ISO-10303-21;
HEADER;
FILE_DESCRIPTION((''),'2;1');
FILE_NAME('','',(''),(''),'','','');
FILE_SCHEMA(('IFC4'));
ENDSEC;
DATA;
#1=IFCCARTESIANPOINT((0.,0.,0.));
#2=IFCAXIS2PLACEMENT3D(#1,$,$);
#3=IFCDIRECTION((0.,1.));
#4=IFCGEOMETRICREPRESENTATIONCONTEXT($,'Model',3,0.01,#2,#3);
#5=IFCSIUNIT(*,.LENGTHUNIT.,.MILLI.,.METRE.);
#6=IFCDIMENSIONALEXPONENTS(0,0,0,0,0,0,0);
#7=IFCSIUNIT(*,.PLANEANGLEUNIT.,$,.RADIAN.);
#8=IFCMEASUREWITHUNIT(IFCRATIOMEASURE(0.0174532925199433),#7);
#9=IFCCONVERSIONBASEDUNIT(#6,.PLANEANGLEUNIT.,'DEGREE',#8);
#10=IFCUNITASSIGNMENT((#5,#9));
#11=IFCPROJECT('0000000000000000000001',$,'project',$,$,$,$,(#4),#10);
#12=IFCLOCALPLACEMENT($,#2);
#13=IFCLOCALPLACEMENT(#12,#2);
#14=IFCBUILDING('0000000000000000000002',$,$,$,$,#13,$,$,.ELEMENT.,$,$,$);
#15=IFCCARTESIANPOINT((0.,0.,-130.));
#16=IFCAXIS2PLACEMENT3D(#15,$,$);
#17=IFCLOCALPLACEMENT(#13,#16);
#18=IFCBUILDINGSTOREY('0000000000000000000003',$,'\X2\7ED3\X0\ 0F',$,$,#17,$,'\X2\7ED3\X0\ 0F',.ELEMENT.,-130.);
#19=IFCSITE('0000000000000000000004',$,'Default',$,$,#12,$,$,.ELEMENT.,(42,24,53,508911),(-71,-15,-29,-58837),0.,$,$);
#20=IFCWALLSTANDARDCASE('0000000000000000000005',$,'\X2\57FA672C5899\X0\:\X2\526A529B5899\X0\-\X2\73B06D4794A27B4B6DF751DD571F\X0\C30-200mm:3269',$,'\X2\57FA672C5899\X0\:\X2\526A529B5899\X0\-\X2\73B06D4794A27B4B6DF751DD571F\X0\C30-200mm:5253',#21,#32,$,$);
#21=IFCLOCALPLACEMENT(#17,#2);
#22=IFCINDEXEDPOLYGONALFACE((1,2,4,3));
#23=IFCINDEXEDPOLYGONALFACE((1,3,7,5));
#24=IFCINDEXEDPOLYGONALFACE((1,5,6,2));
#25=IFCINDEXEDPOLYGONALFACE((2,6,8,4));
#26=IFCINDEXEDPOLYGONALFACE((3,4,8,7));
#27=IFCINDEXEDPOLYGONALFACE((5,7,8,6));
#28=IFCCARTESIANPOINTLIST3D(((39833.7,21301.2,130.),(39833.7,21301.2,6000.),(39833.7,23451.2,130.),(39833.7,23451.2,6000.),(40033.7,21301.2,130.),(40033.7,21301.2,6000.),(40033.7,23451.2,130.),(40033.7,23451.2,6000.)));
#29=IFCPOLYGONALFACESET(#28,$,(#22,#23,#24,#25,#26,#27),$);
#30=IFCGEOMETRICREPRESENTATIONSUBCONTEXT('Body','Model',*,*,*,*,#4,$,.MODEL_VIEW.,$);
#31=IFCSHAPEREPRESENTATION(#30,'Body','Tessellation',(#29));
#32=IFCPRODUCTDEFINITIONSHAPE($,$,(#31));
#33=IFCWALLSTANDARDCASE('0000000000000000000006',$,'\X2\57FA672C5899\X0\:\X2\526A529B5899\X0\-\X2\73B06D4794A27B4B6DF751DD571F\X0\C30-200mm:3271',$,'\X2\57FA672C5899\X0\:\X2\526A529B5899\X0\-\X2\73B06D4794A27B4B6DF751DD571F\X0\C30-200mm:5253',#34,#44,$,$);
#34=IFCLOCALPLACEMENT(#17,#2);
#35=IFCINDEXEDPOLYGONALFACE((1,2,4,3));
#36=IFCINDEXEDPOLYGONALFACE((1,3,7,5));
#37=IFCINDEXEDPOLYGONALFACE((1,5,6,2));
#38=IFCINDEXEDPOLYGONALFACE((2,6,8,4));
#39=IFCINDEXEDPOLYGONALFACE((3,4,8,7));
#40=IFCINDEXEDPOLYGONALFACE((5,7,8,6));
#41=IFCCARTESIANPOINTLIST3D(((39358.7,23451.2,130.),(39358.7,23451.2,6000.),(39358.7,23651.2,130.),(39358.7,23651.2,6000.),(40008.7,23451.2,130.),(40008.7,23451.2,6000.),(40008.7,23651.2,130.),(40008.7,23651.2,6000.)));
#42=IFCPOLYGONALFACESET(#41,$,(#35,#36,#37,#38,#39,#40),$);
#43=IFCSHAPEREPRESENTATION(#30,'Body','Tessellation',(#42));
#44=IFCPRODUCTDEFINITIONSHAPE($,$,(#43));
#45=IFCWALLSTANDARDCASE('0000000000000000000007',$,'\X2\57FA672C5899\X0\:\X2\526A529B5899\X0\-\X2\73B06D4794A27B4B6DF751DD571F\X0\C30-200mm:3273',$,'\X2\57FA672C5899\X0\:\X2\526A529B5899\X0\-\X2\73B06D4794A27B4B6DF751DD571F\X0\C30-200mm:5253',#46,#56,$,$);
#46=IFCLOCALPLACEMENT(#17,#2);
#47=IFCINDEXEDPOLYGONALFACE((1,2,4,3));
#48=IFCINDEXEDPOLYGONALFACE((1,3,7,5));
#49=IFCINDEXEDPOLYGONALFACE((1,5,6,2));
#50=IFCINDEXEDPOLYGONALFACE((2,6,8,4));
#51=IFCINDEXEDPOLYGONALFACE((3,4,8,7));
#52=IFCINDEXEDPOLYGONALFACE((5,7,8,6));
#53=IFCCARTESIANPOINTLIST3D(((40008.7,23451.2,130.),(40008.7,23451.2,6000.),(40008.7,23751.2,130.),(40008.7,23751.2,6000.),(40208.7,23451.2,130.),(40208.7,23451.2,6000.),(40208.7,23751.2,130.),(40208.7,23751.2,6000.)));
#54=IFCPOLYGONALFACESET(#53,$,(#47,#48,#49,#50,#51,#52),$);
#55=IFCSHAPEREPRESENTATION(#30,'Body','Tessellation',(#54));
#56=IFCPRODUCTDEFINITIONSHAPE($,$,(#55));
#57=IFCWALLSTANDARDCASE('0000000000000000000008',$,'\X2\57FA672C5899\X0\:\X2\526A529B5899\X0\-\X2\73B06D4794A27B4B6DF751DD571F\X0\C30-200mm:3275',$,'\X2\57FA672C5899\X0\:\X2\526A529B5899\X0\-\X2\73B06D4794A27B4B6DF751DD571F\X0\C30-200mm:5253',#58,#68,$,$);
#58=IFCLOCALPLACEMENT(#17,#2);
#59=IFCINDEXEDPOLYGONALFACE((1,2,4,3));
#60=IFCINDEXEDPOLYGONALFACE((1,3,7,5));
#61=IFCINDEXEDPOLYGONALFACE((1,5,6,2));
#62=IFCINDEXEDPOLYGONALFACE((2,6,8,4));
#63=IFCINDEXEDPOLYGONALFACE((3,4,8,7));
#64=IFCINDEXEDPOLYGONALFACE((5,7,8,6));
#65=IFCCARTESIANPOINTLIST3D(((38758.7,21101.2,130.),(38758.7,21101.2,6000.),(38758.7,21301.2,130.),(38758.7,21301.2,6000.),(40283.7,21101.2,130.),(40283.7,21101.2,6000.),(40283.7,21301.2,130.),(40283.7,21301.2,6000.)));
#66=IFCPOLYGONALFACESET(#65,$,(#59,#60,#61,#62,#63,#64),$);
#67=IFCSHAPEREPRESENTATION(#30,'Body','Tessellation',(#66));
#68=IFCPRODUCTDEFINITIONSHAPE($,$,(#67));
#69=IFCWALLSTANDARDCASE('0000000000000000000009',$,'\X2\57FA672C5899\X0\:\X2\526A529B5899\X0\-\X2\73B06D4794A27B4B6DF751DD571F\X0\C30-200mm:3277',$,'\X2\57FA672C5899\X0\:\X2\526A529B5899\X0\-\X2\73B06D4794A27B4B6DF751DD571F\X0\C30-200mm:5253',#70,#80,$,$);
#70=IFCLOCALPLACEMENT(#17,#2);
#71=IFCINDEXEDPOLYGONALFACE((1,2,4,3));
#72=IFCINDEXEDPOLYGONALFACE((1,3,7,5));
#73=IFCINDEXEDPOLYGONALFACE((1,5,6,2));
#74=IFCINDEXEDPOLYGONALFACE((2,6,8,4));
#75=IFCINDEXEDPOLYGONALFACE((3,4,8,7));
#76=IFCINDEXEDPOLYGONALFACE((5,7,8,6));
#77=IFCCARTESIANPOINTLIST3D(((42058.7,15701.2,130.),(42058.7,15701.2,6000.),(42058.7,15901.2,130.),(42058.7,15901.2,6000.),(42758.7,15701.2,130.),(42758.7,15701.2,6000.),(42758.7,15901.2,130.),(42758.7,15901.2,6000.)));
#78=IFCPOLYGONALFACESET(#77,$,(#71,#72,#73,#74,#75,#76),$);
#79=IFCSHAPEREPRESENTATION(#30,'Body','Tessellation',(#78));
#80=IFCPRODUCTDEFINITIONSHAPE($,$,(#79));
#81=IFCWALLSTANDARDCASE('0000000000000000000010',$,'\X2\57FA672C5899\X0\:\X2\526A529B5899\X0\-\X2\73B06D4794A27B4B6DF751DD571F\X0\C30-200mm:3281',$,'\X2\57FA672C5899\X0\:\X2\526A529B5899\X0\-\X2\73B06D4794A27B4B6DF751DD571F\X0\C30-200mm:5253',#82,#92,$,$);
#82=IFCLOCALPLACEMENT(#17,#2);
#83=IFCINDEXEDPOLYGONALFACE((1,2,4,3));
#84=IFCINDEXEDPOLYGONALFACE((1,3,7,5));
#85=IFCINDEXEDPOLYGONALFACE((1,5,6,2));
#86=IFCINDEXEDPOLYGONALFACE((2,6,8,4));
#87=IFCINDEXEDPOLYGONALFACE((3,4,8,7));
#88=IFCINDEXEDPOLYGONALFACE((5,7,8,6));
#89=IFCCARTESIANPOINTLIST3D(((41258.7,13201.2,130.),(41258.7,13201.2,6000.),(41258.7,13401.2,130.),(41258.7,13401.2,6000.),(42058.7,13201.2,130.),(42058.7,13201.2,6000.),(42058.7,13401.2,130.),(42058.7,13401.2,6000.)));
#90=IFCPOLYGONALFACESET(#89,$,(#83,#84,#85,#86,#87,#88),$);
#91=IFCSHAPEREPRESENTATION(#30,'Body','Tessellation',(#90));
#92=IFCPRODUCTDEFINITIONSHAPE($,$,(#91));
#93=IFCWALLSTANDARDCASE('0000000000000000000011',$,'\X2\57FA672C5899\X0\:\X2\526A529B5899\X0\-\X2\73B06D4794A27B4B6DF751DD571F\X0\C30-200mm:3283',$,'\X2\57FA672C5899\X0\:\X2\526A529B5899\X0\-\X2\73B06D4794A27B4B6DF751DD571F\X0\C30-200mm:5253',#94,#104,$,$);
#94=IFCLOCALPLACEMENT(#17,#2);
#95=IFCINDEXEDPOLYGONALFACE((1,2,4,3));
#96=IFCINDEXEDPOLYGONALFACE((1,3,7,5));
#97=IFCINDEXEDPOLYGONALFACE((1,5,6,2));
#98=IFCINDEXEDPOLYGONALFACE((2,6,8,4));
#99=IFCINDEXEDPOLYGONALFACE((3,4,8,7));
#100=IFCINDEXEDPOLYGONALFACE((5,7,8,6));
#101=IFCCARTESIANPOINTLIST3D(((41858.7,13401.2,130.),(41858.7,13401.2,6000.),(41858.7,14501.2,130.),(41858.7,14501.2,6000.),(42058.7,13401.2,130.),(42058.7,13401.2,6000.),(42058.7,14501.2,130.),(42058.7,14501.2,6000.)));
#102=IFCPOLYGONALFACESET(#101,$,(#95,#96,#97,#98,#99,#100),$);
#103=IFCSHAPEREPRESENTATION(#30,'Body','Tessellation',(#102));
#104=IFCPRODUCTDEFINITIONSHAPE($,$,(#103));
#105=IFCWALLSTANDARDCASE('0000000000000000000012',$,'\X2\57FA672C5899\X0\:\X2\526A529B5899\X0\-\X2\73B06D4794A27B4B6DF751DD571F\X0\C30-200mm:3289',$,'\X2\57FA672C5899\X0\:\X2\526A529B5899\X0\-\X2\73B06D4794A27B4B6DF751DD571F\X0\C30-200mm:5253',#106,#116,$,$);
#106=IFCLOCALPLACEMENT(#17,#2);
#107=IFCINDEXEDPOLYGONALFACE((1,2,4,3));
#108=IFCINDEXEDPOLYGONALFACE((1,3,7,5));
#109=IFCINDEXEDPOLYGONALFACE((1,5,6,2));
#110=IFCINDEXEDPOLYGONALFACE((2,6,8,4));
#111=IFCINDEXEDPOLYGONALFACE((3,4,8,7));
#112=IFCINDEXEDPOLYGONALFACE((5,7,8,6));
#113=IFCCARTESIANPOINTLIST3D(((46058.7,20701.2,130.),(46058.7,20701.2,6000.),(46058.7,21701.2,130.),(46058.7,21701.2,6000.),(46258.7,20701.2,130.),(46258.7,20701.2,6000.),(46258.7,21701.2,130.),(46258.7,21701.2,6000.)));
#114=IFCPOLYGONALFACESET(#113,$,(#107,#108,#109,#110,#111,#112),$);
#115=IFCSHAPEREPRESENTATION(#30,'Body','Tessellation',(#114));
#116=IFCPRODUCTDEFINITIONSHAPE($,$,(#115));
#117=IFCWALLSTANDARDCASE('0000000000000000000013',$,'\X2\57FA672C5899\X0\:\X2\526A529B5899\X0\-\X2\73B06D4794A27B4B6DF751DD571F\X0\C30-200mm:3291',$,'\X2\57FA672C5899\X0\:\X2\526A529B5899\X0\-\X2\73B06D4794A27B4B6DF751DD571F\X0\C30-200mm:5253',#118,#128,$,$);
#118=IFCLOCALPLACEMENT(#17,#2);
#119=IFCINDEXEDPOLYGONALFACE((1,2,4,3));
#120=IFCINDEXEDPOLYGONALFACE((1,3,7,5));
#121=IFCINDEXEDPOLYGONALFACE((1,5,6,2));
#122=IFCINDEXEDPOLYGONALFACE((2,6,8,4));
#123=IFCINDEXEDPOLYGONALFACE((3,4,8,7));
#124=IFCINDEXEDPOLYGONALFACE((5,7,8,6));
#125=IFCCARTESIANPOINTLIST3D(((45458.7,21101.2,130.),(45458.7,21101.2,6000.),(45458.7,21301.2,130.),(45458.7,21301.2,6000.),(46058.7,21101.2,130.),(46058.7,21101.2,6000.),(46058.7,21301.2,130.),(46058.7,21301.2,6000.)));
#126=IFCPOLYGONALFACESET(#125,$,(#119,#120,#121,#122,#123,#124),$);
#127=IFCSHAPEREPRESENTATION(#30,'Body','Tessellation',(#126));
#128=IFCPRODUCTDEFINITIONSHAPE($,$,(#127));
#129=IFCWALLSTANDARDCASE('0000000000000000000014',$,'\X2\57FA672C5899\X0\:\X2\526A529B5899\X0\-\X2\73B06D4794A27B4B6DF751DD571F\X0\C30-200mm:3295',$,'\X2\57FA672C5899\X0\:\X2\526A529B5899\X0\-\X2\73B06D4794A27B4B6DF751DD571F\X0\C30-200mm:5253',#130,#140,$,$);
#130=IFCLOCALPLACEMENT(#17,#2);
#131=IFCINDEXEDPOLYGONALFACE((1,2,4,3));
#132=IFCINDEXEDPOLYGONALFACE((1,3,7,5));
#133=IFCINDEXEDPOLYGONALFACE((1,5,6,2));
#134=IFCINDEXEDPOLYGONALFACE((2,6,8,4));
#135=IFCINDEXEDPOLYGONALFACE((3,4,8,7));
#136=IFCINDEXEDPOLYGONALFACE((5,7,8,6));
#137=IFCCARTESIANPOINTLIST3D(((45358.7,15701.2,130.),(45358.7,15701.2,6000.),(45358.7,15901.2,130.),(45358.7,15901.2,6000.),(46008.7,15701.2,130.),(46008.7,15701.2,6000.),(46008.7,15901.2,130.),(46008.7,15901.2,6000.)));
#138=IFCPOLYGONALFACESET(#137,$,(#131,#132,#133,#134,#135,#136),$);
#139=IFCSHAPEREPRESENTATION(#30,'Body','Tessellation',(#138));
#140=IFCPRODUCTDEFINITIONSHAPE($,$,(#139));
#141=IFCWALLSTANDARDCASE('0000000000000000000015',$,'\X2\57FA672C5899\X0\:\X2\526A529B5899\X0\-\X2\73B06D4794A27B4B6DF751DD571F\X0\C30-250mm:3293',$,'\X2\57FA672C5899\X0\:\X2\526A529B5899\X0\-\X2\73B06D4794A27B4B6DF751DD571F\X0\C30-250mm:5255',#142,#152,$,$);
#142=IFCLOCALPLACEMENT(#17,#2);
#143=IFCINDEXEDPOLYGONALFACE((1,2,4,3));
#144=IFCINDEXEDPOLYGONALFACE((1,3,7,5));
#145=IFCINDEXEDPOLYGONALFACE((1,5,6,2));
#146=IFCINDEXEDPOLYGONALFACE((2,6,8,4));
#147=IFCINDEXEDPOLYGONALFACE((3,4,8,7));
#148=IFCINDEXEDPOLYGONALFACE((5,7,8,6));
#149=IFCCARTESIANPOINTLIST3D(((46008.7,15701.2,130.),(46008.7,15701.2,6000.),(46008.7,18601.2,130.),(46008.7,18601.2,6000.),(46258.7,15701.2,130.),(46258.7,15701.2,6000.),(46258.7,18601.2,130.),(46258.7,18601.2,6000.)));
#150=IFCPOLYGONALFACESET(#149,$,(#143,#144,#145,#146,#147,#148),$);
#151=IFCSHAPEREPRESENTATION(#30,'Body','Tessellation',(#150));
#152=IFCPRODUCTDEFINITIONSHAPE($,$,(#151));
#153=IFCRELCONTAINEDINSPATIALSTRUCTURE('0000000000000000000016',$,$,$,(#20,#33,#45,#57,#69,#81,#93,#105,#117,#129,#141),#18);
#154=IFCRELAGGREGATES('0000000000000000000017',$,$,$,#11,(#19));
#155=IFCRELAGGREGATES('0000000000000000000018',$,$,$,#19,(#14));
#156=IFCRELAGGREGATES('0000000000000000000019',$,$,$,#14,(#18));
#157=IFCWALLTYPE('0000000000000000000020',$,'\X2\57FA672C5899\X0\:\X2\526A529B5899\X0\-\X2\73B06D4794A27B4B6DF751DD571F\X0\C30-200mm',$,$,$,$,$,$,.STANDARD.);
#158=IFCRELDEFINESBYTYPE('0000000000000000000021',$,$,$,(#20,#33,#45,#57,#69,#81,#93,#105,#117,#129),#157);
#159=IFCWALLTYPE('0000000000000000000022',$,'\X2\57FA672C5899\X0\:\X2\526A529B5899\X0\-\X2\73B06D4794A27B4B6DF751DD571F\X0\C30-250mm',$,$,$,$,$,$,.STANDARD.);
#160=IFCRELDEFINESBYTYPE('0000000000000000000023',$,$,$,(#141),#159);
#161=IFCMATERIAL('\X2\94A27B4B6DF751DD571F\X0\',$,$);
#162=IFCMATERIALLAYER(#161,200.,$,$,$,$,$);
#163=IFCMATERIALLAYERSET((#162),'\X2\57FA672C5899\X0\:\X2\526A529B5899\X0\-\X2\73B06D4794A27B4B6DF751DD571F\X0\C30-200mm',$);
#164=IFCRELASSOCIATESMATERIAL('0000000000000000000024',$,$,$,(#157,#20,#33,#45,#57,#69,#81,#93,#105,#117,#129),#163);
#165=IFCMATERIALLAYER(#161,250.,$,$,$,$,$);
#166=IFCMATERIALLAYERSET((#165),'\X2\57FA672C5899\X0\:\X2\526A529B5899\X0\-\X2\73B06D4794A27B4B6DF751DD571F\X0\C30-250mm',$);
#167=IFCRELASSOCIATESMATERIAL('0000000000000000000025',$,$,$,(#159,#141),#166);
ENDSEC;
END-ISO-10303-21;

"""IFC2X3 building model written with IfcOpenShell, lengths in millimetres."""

from ifc_helpers import new_model, entity, si_unit, converted_unit, direction, frame, frame_2d, origin, place, context, subcontext, project, spatial, rectangle, extrude, material, layer, layer_set, layer_usage, type_object, element, save


model = new_model("IFC2X3")

# Units and contexts
model_context = context("Model", 3, precision=0.01, world=origin(), true_north=direction((0.0, 1.0)))
body_context = subcontext(model_context, "Body", "Model", "MODEL_VIEW")
ifc_project = project(units=[si_unit("LENGTHUNIT", "METRE", prefix="MILLI"), converted_unit("PLANEANGLEUNIT", "DEGREE", entity("IfcRatioMeasure", 0.0174532925199433), si_unit("PLANEANGLEUNIT", "RADIAN"), dimensions=[0, 0, 0, 0, 0, 0, 0])], contexts=[model_context])

# Site, building, storey
site_placement = place(None, origin())
site = spatial("IfcSite", under=ifc_project, at=site_placement, Name="Default", CompositionType="ELEMENT", RefLatitude=(42, 24, 53, 508911), RefLongitude=(-71, -15, -29, -58837), RefElevation=0.0)
building_placement = place(site_placement, origin())
building = spatial("IfcBuilding", under=site, at=building_placement, CompositionType="ELEMENT")
storey_placement = place(building_placement, frame((0.0, 0.0, -130.0)))
storey = spatial("IfcBuildingStorey", under=building, at=storey_placement, Name="结 0F", LongName="结 0F", CompositionType="ELEMENT", Elevation=-130.0)

# Walls
ifc_material = material(Name="钢筋混凝土")
ifc_layer_1 = layer(ifc_material, 200.0)
ifc_layer_set_1 = layer_set([ifc_layer_1], Name="基本墙:剪力墙-现浇钢筋混凝土C30-200mm")
wall_type_1 = type_object("IfcWallType", Name="基本墙:剪力墙-现浇钢筋混凝土C30-200mm", PredefinedType="STANDARD", material=ifc_layer_set_1)
ifc_layer_usage_1 = layer_usage(ifc_layer_set_1, "AXIS2", "POSITIVE", -100.0)
wall_1_placement = place(storey_placement, frame((39933.7, 21301.2, 130.0), z_axis=(0.0, 0.0, 1.0), x_axis=(0.0, 1.0, 0.0)))
element("IfcWallStandardCase", 1, at=wall_1_placement, inside=storey, type_object=wall_type_1, material=ifc_layer_usage_1, Name="基本墙:剪力墙-现浇钢筋混凝土C30-200mm:3269", ObjectType="基本墙:剪力墙-现浇钢筋混凝土C30-200mm:5253", context=body_context, shape_type="SweptSolid", body=[
    extrude(rectangle(XDim=2150.0, YDim=200.0, at=frame_2d((1075.0, 0.0), x_axis=(-1.0, 0.0))), origin(), (0.0, 0.0, 1.0), 5870.0),
])
ifc_layer_usage_2 = layer_usage(ifc_layer_set_1, "AXIS2", "POSITIVE", -100.0)
wall_2_placement = place(storey_placement, frame((39358.7, 23551.2, 130.0)))
element("IfcWallStandardCase", 2, at=wall_2_placement, inside=storey, type_object=wall_type_1, material=ifc_layer_usage_2, Name="基本墙:剪力墙-现浇钢筋混凝土C30-200mm:3271", ObjectType="基本墙:剪力墙-现浇钢筋混凝土C30-200mm:5253", context=body_context, shape_type="SweptSolid", body=[
    extrude(rectangle(XDim=650.0, YDim=200.0, at=frame_2d((325.0, 0.0), x_axis=(-1.0, 0.0))), origin(), (0.0, 0.0, 1.0), 5870.0),
])
ifc_layer_usage_3 = layer_usage(ifc_layer_set_1, "AXIS2", "POSITIVE", -100.0)
wall_3_placement = place(storey_placement, frame((40108.7, 23451.2, 130.0), z_axis=(0.0, 0.0, 1.0), x_axis=(0.0, 1.0, 0.0)))
element("IfcWallStandardCase", 3, at=wall_3_placement, inside=storey, type_object=wall_type_1, material=ifc_layer_usage_3, Name="基本墙:剪力墙-现浇钢筋混凝土C30-200mm:3273", ObjectType="基本墙:剪力墙-现浇钢筋混凝土C30-200mm:5253", context=body_context, shape_type="SweptSolid", body=[
    extrude(rectangle(XDim=300.0, YDim=200.0, at=frame_2d((150.0, 0.0), x_axis=(-1.0, 0.0))), origin(), (0.0, 0.0, 1.0), 5870.0),
])
ifc_layer_usage_4 = layer_usage(ifc_layer_set_1, "AXIS2", "POSITIVE", -100.0)
wall_4_placement = place(storey_placement, frame((40283.7, 21201.2, 130.0), z_axis=(0.0, 0.0, 1.0), x_axis=(-1.0, 0.0, 0.0)))
element("IfcWallStandardCase", 4, at=wall_4_placement, inside=storey, type_object=wall_type_1, material=ifc_layer_usage_4, Name="基本墙:剪力墙-现浇钢筋混凝土C30-200mm:3275", ObjectType="基本墙:剪力墙-现浇钢筋混凝土C30-200mm:5253", context=body_context, shape_type="SweptSolid", body=[
    extrude(rectangle(XDim=1525.0, YDim=200.0, at=frame_2d((762.5, 0.0), x_axis=(-1.0, 0.0))), origin(), (0.0, 0.0, 1.0), 5870.0),
])
ifc_layer_usage_5 = layer_usage(ifc_layer_set_1, "AXIS2", "POSITIVE", -100.0)
wall_5_placement = place(storey_placement, frame((42758.7, 15801.2, 130.0), z_axis=(0.0, 0.0, 1.0), x_axis=(-1.0, 0.0, 0.0)))
element("IfcWallStandardCase", 5, at=wall_5_placement, inside=storey, type_object=wall_type_1, material=ifc_layer_usage_5, Name="基本墙:剪力墙-现浇钢筋混凝土C30-200mm:3277", ObjectType="基本墙:剪力墙-现浇钢筋混凝土C30-200mm:5253", context=body_context, shape_type="SweptSolid", body=[
    extrude(rectangle(XDim=700.0, YDim=200.0, at=frame_2d((350.0, 0.0), x_axis=(-1.0, 0.0))), origin(), (0.0, 0.0, 1.0), 5870.0),
])
ifc_layer_usage_6 = layer_usage(ifc_layer_set_1, "AXIS2", "POSITIVE", -100.0)
wall_6_placement = place(storey_placement, frame((41258.7, 13301.2, 130.0)))
element("IfcWallStandardCase", 6, at=wall_6_placement, inside=storey, type_object=wall_type_1, material=ifc_layer_usage_6, Name="基本墙:剪力墙-现浇钢筋混凝土C30-200mm:3281", ObjectType="基本墙:剪力墙-现浇钢筋混凝土C30-200mm:5253", context=body_context, shape_type="SweptSolid", body=[
    extrude(rectangle(XDim=800.0, YDim=200.0, at=frame_2d((400.0, 0.0), x_axis=(-1.0, 0.0))), origin(), (0.0, 0.0, 1.0), 5870.0),
])
ifc_layer_usage_7 = layer_usage(ifc_layer_set_1, "AXIS2", "POSITIVE", -100.0)
wall_7_placement = place(storey_placement, frame((41958.7, 13401.2, 130.0), z_axis=(0.0, 0.0, 1.0), x_axis=(0.0, 1.0, 0.0)))
element("IfcWallStandardCase", 7, at=wall_7_placement, inside=storey, type_object=wall_type_1, material=ifc_layer_usage_7, Name="基本墙:剪力墙-现浇钢筋混凝土C30-200mm:3283", ObjectType="基本墙:剪力墙-现浇钢筋混凝土C30-200mm:5253", context=body_context, shape_type="SweptSolid", body=[
    extrude(rectangle(XDim=1100.0, YDim=200.0, at=frame_2d((550.0, 0.0), x_axis=(-1.0, 0.0))), origin(), (0.0, 0.0, 1.0), 5870.0),
])
ifc_layer_usage_8 = layer_usage(ifc_layer_set_1, "AXIS2", "NEGATIVE", 100.0)
wall_8_placement = place(storey_placement, frame((46158.7, 21701.2, 130.0), z_axis=(0.0, 0.0, 1.0), x_axis=(0.0, -1.0, 0.0)))
element("IfcWallStandardCase", 8, at=wall_8_placement, inside=storey, type_object=wall_type_1, material=ifc_layer_usage_8, Name="基本墙:剪力墙-现浇钢筋混凝土C30-200mm:3289", ObjectType="基本墙:剪力墙-现浇钢筋混凝土C30-200mm:5253", context=body_context, shape_type="SweptSolid", body=[
    extrude(rectangle(XDim=1000.0, YDim=200.0, at=frame_2d((500.0, 0.0), x_axis=(-1.0, 0.0))), origin(), (0.0, 0.0, 1.0), 5870.0),
])
ifc_layer_usage_9 = layer_usage(ifc_layer_set_1, "AXIS2", "NEGATIVE", 100.0)
wall_9_placement = place(storey_placement, frame((46058.7, 21201.2, 130.0), z_axis=(0.0, 0.0, 1.0), x_axis=(-1.0, 0.0, 0.0)))
element("IfcWallStandardCase", 9, at=wall_9_placement, inside=storey, type_object=wall_type_1, material=ifc_layer_usage_9, Name="基本墙:剪力墙-现浇钢筋混凝土C30-200mm:3291", ObjectType="基本墙:剪力墙-现浇钢筋混凝土C30-200mm:5253", context=body_context, shape_type="SweptSolid", body=[
    extrude(rectangle(XDim=600.0, YDim=200.0, at=frame_2d((300.0, 0.0), x_axis=(-1.0, 0.0))), origin(), (0.0, 0.0, 1.0), 5870.0),
])
ifc_layer_usage_10 = layer_usage(ifc_layer_set_1, "AXIS2", "NEGATIVE", 100.0)
wall_10_placement = place(storey_placement, frame((46008.7, 15801.2, 130.0), z_axis=(0.0, 0.0, 1.0), x_axis=(-1.0, 0.0, 0.0)))
element("IfcWallStandardCase", 10, at=wall_10_placement, inside=storey, type_object=wall_type_1, material=ifc_layer_usage_10, Name="基本墙:剪力墙-现浇钢筋混凝土C30-200mm:3295", ObjectType="基本墙:剪力墙-现浇钢筋混凝土C30-200mm:5253", context=body_context, shape_type="SweptSolid", body=[
    extrude(rectangle(XDim=650.1, YDim=200.0, at=frame_2d((325.0, 0.0), x_axis=(-1.0, 0.0))), origin(), (0.0, 0.0, 1.0), 5870.0),
])
ifc_layer_2 = layer(ifc_material, 250.0)
ifc_layer_set_2 = layer_set([ifc_layer_2], Name="基本墙:剪力墙-现浇钢筋混凝土C30-250mm")
ifc_layer_usage_11 = layer_usage(ifc_layer_set_2, "AXIS2", "NEGATIVE", 125.0)
wall_type_2 = type_object("IfcWallType", Name="基本墙:剪力墙-现浇钢筋混凝土C30-250mm", PredefinedType="STANDARD", material=ifc_layer_set_2)
wall_11_placement = place(storey_placement, frame((46133.7, 18601.2, 130.0), z_axis=(0.0, 0.0, 1.0), x_axis=(0.0, -1.0, 0.0)))
element("IfcWallStandardCase", 11, at=wall_11_placement, inside=storey, type_object=wall_type_2, material=ifc_layer_usage_11, Name="基本墙:剪力墙-现浇钢筋混凝土C30-250mm:3293", ObjectType="基本墙:剪力墙-现浇钢筋混凝土C30-250mm:5255", context=body_context, shape_type="SweptSolid", body=[
    extrude(rectangle(XDim=2900.0, YDim=250.0, at=frame_2d((1450.0, 0.0), x_axis=(-1.0, 0.0))), origin(), (0.0, 0.0, 1.0), 5870.0),
])

save(model, "model.ifc")
